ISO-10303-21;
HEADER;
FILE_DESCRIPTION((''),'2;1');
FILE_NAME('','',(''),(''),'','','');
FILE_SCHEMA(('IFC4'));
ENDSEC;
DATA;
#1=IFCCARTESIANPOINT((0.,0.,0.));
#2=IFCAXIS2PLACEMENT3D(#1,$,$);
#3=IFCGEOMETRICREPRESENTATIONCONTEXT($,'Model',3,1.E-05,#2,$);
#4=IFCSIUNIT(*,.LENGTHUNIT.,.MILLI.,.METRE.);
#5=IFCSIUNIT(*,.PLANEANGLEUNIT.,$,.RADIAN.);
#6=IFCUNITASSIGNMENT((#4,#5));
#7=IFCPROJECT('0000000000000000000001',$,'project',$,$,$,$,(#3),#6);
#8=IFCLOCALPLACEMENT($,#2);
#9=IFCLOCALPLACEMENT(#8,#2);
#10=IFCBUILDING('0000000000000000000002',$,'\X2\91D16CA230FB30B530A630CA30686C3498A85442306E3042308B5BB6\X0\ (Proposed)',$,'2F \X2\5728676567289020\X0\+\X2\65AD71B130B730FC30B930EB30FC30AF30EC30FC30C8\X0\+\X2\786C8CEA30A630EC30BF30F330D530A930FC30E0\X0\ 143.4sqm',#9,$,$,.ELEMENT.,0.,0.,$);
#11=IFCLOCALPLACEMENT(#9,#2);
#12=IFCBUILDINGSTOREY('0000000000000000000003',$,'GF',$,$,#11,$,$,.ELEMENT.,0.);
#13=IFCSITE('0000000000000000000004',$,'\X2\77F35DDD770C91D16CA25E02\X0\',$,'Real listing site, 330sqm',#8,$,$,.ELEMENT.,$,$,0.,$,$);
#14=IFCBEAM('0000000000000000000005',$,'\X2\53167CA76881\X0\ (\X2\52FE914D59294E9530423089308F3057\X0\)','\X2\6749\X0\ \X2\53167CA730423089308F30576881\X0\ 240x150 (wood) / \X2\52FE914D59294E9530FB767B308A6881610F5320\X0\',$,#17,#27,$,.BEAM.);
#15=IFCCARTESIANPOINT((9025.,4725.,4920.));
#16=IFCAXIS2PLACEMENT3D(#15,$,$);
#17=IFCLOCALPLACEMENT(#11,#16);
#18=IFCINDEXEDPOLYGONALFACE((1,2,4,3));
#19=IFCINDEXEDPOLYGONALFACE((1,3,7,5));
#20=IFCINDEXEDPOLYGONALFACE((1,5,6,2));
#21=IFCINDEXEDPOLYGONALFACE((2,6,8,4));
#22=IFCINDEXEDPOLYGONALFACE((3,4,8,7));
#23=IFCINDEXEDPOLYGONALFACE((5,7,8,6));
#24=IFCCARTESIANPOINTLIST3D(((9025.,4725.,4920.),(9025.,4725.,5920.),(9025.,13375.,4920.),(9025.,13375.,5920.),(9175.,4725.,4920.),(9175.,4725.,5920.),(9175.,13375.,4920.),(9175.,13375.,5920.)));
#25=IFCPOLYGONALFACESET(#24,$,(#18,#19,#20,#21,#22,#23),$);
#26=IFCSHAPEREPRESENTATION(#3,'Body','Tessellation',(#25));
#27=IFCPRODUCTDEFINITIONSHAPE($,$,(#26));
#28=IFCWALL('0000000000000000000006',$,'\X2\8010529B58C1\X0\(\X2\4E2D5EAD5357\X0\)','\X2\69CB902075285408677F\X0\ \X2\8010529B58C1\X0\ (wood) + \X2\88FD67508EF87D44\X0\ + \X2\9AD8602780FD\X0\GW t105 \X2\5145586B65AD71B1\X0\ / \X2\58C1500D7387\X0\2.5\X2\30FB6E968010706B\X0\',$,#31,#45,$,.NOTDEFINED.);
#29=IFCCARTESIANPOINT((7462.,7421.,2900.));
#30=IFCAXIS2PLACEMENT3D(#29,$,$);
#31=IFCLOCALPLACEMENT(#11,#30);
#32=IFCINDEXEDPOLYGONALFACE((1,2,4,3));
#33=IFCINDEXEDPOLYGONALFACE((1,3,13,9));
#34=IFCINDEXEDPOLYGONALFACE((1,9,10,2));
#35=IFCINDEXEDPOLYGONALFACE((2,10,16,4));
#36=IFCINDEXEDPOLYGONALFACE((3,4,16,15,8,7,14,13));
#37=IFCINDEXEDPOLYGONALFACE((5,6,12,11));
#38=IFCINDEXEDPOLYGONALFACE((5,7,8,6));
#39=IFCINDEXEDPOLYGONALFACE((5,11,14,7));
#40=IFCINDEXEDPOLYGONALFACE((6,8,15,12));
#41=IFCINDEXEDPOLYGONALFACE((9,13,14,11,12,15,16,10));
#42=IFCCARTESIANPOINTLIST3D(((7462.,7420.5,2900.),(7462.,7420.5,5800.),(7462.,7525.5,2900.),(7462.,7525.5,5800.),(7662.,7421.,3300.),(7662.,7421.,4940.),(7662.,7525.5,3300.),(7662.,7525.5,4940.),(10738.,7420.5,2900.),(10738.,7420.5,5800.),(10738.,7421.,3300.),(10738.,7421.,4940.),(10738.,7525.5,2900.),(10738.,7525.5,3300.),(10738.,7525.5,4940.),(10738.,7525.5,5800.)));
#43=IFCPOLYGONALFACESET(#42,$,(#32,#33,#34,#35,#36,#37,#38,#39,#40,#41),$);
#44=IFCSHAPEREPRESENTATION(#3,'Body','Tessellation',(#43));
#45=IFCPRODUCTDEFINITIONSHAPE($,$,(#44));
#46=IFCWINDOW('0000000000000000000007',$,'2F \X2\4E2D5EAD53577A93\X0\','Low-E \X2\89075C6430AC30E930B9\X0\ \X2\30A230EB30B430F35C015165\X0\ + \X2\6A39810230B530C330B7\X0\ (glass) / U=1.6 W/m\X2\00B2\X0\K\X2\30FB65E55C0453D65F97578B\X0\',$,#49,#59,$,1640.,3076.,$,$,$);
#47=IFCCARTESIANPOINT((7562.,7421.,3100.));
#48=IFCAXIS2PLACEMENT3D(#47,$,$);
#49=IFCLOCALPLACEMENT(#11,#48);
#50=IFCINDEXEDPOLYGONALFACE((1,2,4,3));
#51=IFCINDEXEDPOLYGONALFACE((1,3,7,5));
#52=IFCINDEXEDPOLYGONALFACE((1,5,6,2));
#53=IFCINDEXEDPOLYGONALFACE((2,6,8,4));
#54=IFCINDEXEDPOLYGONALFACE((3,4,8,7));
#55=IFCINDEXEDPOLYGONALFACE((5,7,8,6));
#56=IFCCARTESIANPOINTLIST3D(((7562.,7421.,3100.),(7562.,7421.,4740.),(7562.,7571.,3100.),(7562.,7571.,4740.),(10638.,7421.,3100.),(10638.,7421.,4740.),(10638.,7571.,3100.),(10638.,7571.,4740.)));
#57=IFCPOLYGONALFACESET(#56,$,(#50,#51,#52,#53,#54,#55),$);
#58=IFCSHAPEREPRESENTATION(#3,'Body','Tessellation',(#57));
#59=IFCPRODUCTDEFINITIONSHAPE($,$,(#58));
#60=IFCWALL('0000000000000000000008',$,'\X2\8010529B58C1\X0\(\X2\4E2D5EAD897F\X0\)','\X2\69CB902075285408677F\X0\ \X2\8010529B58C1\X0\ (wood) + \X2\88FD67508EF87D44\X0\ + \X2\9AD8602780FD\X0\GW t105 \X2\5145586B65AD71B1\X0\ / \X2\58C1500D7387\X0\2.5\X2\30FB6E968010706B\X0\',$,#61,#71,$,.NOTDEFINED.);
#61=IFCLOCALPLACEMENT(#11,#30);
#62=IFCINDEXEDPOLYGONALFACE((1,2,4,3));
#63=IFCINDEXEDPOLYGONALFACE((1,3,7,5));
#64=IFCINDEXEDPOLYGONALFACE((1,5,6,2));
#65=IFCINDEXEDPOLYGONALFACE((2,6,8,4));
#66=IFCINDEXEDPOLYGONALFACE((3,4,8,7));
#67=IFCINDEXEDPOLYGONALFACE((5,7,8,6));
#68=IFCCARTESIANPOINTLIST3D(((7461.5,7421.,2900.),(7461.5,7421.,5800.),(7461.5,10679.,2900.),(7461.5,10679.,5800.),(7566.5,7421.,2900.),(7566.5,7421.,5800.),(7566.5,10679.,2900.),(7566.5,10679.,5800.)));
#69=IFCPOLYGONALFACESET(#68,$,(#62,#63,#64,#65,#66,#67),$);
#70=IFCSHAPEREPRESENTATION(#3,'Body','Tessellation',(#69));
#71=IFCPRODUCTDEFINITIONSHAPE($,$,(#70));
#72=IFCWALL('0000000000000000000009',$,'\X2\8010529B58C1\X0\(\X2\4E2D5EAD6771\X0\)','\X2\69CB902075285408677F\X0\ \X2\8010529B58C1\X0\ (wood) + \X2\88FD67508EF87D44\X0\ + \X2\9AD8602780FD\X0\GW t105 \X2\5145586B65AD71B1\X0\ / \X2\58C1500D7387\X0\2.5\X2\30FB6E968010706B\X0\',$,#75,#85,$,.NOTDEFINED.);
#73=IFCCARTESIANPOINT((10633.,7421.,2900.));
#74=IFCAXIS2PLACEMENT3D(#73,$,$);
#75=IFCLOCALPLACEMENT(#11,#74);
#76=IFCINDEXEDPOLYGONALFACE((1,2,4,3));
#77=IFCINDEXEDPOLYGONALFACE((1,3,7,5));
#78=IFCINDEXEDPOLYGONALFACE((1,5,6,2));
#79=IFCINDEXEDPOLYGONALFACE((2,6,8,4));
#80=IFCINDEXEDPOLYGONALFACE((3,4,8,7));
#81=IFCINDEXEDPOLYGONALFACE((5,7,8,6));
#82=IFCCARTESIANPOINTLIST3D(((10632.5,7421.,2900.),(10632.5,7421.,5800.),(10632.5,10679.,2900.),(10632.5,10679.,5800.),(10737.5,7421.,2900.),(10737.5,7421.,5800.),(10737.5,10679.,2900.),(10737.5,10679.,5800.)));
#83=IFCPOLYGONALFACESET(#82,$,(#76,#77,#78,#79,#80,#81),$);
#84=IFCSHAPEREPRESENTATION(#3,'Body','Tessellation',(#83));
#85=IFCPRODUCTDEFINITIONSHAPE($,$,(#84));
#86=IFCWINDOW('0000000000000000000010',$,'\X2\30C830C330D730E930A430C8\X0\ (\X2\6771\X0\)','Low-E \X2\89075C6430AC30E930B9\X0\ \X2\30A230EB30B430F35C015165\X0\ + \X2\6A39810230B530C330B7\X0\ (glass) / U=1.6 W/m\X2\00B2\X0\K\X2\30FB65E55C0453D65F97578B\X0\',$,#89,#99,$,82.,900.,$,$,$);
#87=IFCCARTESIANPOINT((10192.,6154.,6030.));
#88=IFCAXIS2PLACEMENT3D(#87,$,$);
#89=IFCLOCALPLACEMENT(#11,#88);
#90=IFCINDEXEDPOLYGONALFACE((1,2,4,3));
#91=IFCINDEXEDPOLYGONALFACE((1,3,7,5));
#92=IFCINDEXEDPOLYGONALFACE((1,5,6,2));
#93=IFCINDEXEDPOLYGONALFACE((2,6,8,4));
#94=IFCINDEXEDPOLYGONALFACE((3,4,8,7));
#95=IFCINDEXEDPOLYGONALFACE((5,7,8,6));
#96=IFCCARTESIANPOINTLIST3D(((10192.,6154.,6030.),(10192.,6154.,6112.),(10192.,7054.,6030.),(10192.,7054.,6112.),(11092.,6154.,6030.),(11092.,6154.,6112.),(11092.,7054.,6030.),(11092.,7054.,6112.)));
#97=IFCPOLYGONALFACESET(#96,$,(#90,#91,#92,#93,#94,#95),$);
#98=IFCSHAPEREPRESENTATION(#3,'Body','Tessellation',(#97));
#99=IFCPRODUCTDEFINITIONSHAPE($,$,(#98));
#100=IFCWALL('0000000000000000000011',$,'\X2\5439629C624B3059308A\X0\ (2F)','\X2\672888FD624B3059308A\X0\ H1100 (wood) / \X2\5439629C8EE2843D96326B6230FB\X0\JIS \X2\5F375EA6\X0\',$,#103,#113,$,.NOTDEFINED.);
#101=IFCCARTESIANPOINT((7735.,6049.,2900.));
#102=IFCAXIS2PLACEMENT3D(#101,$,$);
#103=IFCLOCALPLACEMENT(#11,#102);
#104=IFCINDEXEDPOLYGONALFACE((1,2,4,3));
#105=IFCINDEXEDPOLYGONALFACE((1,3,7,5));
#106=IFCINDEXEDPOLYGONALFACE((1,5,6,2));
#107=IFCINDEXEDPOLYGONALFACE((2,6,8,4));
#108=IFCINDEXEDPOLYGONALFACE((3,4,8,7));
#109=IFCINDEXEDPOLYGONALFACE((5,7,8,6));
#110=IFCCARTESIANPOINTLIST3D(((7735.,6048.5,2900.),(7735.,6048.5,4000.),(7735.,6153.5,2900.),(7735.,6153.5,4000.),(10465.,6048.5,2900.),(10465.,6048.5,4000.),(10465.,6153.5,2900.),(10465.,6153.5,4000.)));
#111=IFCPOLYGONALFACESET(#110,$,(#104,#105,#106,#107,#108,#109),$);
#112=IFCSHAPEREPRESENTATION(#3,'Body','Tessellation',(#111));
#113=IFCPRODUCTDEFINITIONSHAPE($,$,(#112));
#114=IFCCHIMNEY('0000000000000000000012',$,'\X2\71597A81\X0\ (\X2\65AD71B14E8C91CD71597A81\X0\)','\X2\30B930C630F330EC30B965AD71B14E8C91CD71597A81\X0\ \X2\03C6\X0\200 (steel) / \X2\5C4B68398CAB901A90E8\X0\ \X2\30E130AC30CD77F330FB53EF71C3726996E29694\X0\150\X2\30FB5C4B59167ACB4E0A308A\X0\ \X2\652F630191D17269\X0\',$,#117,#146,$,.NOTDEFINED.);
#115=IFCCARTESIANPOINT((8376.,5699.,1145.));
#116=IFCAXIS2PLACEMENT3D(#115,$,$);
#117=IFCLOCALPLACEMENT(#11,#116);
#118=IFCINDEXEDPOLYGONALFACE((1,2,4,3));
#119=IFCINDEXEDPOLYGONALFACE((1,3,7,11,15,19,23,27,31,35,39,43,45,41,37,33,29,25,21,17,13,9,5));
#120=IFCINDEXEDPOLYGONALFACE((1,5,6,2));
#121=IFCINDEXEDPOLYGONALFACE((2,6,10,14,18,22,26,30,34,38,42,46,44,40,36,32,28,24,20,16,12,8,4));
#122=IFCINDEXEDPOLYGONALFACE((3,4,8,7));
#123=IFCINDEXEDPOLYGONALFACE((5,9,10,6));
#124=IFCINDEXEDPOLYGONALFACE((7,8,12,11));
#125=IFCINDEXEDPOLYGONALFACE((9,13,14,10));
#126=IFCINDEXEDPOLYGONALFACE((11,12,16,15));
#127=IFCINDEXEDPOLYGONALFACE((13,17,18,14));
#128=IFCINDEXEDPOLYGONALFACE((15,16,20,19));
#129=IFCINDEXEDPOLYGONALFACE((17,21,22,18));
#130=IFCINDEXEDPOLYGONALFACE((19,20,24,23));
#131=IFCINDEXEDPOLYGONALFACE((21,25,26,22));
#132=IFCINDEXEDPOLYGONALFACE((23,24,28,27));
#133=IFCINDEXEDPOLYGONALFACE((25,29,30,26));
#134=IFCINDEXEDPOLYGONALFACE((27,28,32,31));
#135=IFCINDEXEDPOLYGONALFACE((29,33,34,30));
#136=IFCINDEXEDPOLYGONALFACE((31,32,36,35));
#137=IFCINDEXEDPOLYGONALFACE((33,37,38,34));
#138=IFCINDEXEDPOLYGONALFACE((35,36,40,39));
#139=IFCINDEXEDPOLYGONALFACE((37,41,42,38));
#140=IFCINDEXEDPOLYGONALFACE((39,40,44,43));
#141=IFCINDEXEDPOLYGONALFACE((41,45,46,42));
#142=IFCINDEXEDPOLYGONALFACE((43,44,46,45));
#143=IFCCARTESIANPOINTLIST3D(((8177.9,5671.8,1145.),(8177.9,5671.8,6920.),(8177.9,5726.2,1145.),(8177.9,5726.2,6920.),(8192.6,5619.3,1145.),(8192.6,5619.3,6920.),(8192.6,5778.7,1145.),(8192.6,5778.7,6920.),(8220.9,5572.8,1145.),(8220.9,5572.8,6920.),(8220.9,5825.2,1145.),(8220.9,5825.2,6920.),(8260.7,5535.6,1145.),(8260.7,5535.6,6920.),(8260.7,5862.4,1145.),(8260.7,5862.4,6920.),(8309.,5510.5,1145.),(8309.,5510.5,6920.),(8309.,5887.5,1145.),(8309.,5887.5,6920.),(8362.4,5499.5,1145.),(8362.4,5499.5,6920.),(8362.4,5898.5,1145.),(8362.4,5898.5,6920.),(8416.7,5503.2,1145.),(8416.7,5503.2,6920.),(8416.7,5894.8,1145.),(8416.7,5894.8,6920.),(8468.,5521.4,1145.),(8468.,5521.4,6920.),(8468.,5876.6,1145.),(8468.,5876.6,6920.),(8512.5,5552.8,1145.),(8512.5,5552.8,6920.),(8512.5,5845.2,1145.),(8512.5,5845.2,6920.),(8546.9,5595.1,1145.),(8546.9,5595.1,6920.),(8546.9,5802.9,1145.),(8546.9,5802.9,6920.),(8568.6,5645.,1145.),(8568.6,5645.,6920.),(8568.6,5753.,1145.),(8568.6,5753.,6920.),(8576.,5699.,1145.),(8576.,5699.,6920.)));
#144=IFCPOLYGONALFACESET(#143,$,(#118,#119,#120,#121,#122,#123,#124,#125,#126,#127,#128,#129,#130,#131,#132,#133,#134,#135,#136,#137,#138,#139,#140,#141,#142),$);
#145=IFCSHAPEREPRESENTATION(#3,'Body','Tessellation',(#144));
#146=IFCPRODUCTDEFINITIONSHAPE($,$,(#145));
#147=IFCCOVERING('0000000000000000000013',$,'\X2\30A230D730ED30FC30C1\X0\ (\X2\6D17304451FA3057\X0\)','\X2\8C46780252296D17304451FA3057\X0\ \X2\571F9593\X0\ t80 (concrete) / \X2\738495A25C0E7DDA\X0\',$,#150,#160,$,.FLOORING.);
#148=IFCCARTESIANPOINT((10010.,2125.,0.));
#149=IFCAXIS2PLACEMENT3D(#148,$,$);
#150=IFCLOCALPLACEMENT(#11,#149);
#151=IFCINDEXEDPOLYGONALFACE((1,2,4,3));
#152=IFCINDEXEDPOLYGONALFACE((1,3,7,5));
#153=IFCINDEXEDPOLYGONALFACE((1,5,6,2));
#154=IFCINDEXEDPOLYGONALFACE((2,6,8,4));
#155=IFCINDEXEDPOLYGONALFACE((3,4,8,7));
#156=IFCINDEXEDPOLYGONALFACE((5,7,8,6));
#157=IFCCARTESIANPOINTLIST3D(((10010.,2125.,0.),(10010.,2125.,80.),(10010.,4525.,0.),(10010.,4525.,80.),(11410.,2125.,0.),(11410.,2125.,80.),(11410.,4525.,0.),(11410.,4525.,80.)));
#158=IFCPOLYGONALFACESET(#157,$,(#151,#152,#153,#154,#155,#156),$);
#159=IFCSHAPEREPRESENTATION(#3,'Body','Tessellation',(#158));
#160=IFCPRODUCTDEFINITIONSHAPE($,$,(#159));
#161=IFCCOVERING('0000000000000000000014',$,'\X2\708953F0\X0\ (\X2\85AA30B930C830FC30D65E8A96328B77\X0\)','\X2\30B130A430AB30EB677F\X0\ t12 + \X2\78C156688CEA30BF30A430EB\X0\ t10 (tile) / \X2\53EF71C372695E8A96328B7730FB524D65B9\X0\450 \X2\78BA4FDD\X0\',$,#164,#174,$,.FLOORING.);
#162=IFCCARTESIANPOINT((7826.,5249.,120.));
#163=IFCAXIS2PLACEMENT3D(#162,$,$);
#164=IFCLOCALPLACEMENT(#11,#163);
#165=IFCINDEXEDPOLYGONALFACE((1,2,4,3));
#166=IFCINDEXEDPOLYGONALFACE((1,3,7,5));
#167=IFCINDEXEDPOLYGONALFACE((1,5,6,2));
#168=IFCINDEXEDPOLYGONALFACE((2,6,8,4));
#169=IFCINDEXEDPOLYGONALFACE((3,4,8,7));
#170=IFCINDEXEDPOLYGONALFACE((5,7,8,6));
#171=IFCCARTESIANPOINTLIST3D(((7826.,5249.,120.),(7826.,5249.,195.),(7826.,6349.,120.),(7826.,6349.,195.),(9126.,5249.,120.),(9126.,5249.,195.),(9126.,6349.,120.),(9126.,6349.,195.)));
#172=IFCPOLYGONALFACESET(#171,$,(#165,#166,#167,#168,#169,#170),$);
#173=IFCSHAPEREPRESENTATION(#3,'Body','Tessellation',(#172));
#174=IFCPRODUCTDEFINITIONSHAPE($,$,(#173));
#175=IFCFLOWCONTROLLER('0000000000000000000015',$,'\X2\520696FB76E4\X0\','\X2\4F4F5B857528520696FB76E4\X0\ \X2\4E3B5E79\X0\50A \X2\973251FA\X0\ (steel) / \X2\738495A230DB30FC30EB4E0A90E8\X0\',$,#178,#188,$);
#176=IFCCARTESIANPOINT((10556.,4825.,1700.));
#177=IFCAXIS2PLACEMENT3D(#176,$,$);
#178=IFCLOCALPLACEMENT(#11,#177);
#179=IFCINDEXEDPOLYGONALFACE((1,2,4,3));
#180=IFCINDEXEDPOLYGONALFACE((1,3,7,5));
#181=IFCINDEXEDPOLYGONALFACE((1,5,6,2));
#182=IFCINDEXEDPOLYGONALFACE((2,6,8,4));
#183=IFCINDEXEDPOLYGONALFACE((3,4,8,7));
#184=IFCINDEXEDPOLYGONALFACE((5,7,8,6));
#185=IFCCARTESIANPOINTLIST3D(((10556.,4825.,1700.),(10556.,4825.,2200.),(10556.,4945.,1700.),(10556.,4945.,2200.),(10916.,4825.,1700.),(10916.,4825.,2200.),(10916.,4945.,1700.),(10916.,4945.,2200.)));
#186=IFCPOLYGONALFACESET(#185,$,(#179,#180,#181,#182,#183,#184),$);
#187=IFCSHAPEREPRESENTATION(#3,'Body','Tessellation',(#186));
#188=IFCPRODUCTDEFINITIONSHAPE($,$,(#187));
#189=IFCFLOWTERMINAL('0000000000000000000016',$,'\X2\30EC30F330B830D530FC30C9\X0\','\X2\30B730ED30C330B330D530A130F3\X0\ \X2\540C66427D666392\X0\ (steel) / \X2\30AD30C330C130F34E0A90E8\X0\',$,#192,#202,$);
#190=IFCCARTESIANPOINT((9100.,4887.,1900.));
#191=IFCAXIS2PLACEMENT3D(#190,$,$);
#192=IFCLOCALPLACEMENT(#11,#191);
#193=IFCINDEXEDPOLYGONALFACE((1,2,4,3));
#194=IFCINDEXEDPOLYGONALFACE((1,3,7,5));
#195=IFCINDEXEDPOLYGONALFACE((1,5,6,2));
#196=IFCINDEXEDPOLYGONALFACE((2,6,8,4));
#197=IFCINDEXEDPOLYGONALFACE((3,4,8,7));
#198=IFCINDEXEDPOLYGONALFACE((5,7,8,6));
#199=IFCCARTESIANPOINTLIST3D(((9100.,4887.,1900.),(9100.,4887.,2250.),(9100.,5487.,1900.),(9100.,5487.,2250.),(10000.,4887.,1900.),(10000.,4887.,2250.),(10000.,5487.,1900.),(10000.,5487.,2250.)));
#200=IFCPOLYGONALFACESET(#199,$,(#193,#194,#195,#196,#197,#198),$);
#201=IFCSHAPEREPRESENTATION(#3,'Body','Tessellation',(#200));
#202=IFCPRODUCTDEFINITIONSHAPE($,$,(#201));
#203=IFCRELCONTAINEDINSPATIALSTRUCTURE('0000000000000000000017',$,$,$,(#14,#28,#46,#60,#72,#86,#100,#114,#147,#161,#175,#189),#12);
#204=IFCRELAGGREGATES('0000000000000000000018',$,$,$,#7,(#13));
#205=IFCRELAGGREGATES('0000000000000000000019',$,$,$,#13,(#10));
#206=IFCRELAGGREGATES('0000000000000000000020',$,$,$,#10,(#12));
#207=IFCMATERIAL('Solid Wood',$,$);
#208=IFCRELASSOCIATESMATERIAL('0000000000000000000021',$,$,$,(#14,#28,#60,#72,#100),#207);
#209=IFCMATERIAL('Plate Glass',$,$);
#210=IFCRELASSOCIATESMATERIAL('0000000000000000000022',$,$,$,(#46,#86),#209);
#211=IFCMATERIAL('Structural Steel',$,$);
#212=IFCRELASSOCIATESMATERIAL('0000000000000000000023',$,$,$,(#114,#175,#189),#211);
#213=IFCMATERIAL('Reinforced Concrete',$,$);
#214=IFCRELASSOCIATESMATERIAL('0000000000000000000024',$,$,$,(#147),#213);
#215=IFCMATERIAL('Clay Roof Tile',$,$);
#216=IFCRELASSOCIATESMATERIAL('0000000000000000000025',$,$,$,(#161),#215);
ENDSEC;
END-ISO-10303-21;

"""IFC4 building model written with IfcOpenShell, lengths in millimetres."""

from ifc_helpers import new_model, si_unit, frame, frame_2d, origin, origin_2d, place, context, project, spatial, rectangle, circle, extrude, material, element, fill, save


model = new_model("IFC4")

# Units and contexts
model_context = context("Model", 3, precision=1e-05, world=origin())
ifc_project = project(units=[si_unit("LENGTHUNIT", "METRE", prefix="MILLI"), si_unit("PLANEANGLEUNIT", "RADIAN")], contexts=[model_context])

# Site, building, storey
site_placement = place(None, origin())
site = spatial("IfcSite", under=ifc_project, at=site_placement, Name="石川県金沢市", ObjectType="Real listing site, 330sqm", CompositionType="ELEMENT", RefElevation=0.0)
building_placement = place(site_placement, origin())
building = spatial("IfcBuilding", under=site, at=building_placement, Name="金沢・サウナと水風呂のある家 (Proposed)", ObjectType="2F 在来木造+断熱シースルークレート+硬質ウレタンフォーム 143.4sqm", CompositionType="ELEMENT", ElevationOfRefHeight=0.0, ElevationOfTerrain=0.0)
storey_placement = place(building_placement, origin())
storey = spatial("IfcBuildingStorey", under=building, at=storey_placement, Name="GF", CompositionType="ELEMENT", Elevation=0.0)

# Shared definitions
ifc_material_1 = material(Name="Solid Wood")

# Beam
beam_placement = place(storey_placement, frame((9025.0, 4725.0, 4920.0)))
element("IfcBeam", 1, at=beam_placement, inside=storey, material=ifc_material_1, Name="化粧梁 (勾配天井あらわし)", Description="杉 化粧あらわし梁 240x150 (wood) / 勾配天井・登り梁意匠", PredefinedType="BEAM", context=model_context, shape_type="SweptSolid", body=[
    extrude(rectangle(XDim=150.0, YDim=8650.0, at=frame_2d((75.0, 4325.0))), frame((9025.0, 4725.0, 4920.0)), (0.0, 0.0, 1.0), 1000.0),
])

# Wall, opening, window
wall_1_placement = place(storey_placement, frame((7462.0, 7421.0, 2900.0)))
wall_1 = element("IfcWall", 2, at=wall_1_placement, inside=storey, material=ifc_material_1, Name="耐力壁(中庭南)", Description="構造用合板 耐力壁 (wood) + 製材軸組 + 高性能GW t105 充填断熱 / 壁倍率2.5・準耐火", PredefinedType="NOTDEFINED", context=model_context, shape_type="SweptSolid", body=[
    extrude(rectangle(XDim=3276.0, YDim=105.0, at=frame_2d((1638.0, 52.0))), frame((7462.0, 7421.0, 2900.0)), (0.0, 0.0, 1.0), 2900.0),
])
opening_placement = place(storey_placement, frame((7562.0, 7421.0, 3100.0)))
opening = element("IfcOpeningElement", 3, at=opening_placement, cuts=wall_1, PredefinedType="NOTDEFINED", context=model_context, shape_type="SweptSolid", body=[
    extrude(rectangle(XDim=3076.0, YDim=150.0, at=frame_2d((1538.0, 75.0))), frame((7562.0, 7421.0, 3100.0)), (0.0, 0.0, 1.0), 1640.0),
])
ifc_material_2 = material(Name="Plate Glass")
window_1_placement = place(storey_placement, frame((7562.0, 7421.0, 3100.0)))
window_1 = element("IfcWindow", 4, at=window_1_placement, inside=storey, material=ifc_material_2, Name="2F 中庭南窓", Description="Low-E 複層ガラス アルゴン封入 + 樹脂サッシ (glass) / U=1.6 W/m²K・日射取得型", OverallHeight=1640.0, OverallWidth=3076.0, context=model_context, shape_type="SweptSolid", body=[
    extrude(rectangle(XDim=3076.0, YDim=150.0, at=frame_2d((1538.0, 75.0))), frame((7562.0, 7421.0, 3100.0)), (0.0, 0.0, 1.0), 1640.0),
])
fill(opening, window_1)

# Walls
wall_2_placement = place(storey_placement, frame((7462.0, 7421.0, 2900.0)))
element("IfcWall", 5, at=wall_2_placement, inside=storey, material=ifc_material_1, Name="耐力壁(中庭西)", Description="構造用合板 耐力壁 (wood) + 製材軸組 + 高性能GW t105 充填断熱 / 壁倍率2.5・準耐火", PredefinedType="NOTDEFINED", context=model_context, shape_type="SweptSolid", body=[
    extrude(rectangle(XDim=105.0, YDim=3258.0, at=frame_2d((52.0, 1629.0))), frame((7462.0, 7421.0, 2900.0)), (0.0, 0.0, 1.0), 2900.0),
])
wall_3_placement = place(storey_placement, frame((10633.0, 7421.0, 2900.0)))
element("IfcWall", 6, at=wall_3_placement, inside=storey, material=ifc_material_1, Name="耐力壁(中庭東)", Description="構造用合板 耐力壁 (wood) + 製材軸組 + 高性能GW t105 充填断熱 / 壁倍率2.5・準耐火", PredefinedType="NOTDEFINED", context=model_context, shape_type="SweptSolid", body=[
    extrude(rectangle(XDim=105.0, YDim=3258.0, at=frame_2d((52.0, 1629.0))), frame((10633.0, 7421.0, 2900.0)), (0.0, 0.0, 1.0), 2900.0),
])

# Window
window_2_placement = place(storey_placement, frame((10192.0, 6154.0, 6030.0)))
element("IfcWindow", 7, at=window_2_placement, inside=storey, material=ifc_material_2, Name="トップライト (東)", Description="Low-E 複層ガラス アルゴン封入 + 樹脂サッシ (glass) / U=1.6 W/m²K・日射取得型", OverallHeight=82.0, OverallWidth=900.0, context=model_context, shape_type="SweptSolid", body=[
    extrude(rectangle(XDim=900.0, YDim=900.0, at=frame_2d((450.0, 450.0))), frame((10192.0, 6154.0, 6030.0)), (0.0, 0.0, 1.0), 82.0),
])

# Wall
wall_4_placement = place(storey_placement, frame((7735.0, 6049.0, 2900.0)))
element("IfcWall", 8, at=wall_4_placement, inside=storey, material=ifc_material_1, Name="吹抜手すり (2F)", Description="木製手すり H1100 (wood) / 吹抜転落防止・JIS 強度", PredefinedType="NOTDEFINED", context=model_context, shape_type="SweptSolid", body=[
    extrude(rectangle(XDim=2730.0, YDim=105.0, at=frame_2d((1365.0, 52.0))), frame((7735.0, 6049.0, 2900.0)), (0.0, 0.0, 1.0), 1100.0),
])

# Chimney
ifc_material_3 = material(Name="Structural Steel")
chimney_placement = place(storey_placement, frame((8376.0, 5699.0, 1145.0)))
element("IfcChimney", 9, at=chimney_placement, inside=storey, material=ifc_material_3, Name="煙突 (断熱二重煙突)", Description="ステンレス断熱二重煙突 φ200 (steel) / 屋根貫通部 メガネ石・可燃物離隔150・屋外立上り 支持金物", PredefinedType="NOTDEFINED", context=model_context, shape_type="SweptSolid", body=[
    extrude(circle(Radius=200.0, at=origin_2d()), frame((8376.0, 5699.0, 1145.0)), (0.0, 0.0, 1.0), 5775.0),
])

# Coverings
ifc_material_4 = material(Name="Reinforced Concrete")
covering_1_placement = place(storey_placement, frame((10010.0, 2125.0, 0.0)))
element("IfcCovering", 10, at=covering_1_placement, inside=storey, material=ifc_material_4, Name="アプローチ (洗い出し)", Description="豆砂利洗い出し 土間 t80 (concrete) / 玄関導線", PredefinedType="FLOORING", context=model_context, shape_type="SweptSolid", body=[
    extrude(rectangle(XDim=1400.0, YDim=2400.0, at=frame_2d((700.0, 1200.0))), frame((10010.0, 2125.0, 0.0)), (0.0, 0.0, 1.0), 80.0),
])
ifc_material_5 = material(Name="Clay Roof Tile")
covering_2_placement = place(storey_placement, frame((7826.0, 5249.0, 120.0)))
element("IfcCovering", 11, at=covering_2_placement, inside=storey, material=ifc_material_5, Name="炉台 (薪ストーブ床防護)", Description="ケイカル板 t12 + 磁器質タイル t10 (tile) / 可燃物床防護・前方450 確保", PredefinedType="FLOORING", context=model_context, shape_type="SweptSolid", body=[
    extrude(rectangle(XDim=1300.0, YDim=1100.0, at=frame_2d((650.0, 550.0))), frame((7826.0, 5249.0, 120.0)), (0.0, 0.0, 1.0), 75.0),
])

# Flow controller
flow_controller_placement = place(storey_placement, frame((10556.0, 4825.0, 1700.0)))
element("IfcFlowController", 12, at=flow_controller_placement, inside=storey, material=ifc_material_3, Name="分電盤", Description="住宅用分電盤 主幹50A 露出 (steel) / 玄関ホール上部", context=model_context, shape_type="SweptSolid", body=[
    extrude(rectangle(XDim=360.0, YDim=120.0, at=frame_2d((180.0, 60.0))), frame((10556.0, 4825.0, 1700.0)), (0.0, 0.0, 1.0), 500.0),
])

# Flow terminal
flow_terminal_1_placement = place(storey_placement, frame((9100.0, 4887.0, 1900.0)))
element("IfcFlowTerminal", 13, at=flow_terminal_1_placement, inside=storey, material=ifc_material_3, Name="レンジフード", Description="シロッコファン 同時給排 (steel) / キッチン上部", context=model_context, shape_type="SweptSolid", body=[
    extrude(rectangle(XDim=900.0, YDim=600.0, at=frame_2d((450.0, 300.0))), frame((9100.0, 4887.0, 1900.0)), (0.0, 0.0, 1.0), 350.0),
])

save(model, "model.ifc")
